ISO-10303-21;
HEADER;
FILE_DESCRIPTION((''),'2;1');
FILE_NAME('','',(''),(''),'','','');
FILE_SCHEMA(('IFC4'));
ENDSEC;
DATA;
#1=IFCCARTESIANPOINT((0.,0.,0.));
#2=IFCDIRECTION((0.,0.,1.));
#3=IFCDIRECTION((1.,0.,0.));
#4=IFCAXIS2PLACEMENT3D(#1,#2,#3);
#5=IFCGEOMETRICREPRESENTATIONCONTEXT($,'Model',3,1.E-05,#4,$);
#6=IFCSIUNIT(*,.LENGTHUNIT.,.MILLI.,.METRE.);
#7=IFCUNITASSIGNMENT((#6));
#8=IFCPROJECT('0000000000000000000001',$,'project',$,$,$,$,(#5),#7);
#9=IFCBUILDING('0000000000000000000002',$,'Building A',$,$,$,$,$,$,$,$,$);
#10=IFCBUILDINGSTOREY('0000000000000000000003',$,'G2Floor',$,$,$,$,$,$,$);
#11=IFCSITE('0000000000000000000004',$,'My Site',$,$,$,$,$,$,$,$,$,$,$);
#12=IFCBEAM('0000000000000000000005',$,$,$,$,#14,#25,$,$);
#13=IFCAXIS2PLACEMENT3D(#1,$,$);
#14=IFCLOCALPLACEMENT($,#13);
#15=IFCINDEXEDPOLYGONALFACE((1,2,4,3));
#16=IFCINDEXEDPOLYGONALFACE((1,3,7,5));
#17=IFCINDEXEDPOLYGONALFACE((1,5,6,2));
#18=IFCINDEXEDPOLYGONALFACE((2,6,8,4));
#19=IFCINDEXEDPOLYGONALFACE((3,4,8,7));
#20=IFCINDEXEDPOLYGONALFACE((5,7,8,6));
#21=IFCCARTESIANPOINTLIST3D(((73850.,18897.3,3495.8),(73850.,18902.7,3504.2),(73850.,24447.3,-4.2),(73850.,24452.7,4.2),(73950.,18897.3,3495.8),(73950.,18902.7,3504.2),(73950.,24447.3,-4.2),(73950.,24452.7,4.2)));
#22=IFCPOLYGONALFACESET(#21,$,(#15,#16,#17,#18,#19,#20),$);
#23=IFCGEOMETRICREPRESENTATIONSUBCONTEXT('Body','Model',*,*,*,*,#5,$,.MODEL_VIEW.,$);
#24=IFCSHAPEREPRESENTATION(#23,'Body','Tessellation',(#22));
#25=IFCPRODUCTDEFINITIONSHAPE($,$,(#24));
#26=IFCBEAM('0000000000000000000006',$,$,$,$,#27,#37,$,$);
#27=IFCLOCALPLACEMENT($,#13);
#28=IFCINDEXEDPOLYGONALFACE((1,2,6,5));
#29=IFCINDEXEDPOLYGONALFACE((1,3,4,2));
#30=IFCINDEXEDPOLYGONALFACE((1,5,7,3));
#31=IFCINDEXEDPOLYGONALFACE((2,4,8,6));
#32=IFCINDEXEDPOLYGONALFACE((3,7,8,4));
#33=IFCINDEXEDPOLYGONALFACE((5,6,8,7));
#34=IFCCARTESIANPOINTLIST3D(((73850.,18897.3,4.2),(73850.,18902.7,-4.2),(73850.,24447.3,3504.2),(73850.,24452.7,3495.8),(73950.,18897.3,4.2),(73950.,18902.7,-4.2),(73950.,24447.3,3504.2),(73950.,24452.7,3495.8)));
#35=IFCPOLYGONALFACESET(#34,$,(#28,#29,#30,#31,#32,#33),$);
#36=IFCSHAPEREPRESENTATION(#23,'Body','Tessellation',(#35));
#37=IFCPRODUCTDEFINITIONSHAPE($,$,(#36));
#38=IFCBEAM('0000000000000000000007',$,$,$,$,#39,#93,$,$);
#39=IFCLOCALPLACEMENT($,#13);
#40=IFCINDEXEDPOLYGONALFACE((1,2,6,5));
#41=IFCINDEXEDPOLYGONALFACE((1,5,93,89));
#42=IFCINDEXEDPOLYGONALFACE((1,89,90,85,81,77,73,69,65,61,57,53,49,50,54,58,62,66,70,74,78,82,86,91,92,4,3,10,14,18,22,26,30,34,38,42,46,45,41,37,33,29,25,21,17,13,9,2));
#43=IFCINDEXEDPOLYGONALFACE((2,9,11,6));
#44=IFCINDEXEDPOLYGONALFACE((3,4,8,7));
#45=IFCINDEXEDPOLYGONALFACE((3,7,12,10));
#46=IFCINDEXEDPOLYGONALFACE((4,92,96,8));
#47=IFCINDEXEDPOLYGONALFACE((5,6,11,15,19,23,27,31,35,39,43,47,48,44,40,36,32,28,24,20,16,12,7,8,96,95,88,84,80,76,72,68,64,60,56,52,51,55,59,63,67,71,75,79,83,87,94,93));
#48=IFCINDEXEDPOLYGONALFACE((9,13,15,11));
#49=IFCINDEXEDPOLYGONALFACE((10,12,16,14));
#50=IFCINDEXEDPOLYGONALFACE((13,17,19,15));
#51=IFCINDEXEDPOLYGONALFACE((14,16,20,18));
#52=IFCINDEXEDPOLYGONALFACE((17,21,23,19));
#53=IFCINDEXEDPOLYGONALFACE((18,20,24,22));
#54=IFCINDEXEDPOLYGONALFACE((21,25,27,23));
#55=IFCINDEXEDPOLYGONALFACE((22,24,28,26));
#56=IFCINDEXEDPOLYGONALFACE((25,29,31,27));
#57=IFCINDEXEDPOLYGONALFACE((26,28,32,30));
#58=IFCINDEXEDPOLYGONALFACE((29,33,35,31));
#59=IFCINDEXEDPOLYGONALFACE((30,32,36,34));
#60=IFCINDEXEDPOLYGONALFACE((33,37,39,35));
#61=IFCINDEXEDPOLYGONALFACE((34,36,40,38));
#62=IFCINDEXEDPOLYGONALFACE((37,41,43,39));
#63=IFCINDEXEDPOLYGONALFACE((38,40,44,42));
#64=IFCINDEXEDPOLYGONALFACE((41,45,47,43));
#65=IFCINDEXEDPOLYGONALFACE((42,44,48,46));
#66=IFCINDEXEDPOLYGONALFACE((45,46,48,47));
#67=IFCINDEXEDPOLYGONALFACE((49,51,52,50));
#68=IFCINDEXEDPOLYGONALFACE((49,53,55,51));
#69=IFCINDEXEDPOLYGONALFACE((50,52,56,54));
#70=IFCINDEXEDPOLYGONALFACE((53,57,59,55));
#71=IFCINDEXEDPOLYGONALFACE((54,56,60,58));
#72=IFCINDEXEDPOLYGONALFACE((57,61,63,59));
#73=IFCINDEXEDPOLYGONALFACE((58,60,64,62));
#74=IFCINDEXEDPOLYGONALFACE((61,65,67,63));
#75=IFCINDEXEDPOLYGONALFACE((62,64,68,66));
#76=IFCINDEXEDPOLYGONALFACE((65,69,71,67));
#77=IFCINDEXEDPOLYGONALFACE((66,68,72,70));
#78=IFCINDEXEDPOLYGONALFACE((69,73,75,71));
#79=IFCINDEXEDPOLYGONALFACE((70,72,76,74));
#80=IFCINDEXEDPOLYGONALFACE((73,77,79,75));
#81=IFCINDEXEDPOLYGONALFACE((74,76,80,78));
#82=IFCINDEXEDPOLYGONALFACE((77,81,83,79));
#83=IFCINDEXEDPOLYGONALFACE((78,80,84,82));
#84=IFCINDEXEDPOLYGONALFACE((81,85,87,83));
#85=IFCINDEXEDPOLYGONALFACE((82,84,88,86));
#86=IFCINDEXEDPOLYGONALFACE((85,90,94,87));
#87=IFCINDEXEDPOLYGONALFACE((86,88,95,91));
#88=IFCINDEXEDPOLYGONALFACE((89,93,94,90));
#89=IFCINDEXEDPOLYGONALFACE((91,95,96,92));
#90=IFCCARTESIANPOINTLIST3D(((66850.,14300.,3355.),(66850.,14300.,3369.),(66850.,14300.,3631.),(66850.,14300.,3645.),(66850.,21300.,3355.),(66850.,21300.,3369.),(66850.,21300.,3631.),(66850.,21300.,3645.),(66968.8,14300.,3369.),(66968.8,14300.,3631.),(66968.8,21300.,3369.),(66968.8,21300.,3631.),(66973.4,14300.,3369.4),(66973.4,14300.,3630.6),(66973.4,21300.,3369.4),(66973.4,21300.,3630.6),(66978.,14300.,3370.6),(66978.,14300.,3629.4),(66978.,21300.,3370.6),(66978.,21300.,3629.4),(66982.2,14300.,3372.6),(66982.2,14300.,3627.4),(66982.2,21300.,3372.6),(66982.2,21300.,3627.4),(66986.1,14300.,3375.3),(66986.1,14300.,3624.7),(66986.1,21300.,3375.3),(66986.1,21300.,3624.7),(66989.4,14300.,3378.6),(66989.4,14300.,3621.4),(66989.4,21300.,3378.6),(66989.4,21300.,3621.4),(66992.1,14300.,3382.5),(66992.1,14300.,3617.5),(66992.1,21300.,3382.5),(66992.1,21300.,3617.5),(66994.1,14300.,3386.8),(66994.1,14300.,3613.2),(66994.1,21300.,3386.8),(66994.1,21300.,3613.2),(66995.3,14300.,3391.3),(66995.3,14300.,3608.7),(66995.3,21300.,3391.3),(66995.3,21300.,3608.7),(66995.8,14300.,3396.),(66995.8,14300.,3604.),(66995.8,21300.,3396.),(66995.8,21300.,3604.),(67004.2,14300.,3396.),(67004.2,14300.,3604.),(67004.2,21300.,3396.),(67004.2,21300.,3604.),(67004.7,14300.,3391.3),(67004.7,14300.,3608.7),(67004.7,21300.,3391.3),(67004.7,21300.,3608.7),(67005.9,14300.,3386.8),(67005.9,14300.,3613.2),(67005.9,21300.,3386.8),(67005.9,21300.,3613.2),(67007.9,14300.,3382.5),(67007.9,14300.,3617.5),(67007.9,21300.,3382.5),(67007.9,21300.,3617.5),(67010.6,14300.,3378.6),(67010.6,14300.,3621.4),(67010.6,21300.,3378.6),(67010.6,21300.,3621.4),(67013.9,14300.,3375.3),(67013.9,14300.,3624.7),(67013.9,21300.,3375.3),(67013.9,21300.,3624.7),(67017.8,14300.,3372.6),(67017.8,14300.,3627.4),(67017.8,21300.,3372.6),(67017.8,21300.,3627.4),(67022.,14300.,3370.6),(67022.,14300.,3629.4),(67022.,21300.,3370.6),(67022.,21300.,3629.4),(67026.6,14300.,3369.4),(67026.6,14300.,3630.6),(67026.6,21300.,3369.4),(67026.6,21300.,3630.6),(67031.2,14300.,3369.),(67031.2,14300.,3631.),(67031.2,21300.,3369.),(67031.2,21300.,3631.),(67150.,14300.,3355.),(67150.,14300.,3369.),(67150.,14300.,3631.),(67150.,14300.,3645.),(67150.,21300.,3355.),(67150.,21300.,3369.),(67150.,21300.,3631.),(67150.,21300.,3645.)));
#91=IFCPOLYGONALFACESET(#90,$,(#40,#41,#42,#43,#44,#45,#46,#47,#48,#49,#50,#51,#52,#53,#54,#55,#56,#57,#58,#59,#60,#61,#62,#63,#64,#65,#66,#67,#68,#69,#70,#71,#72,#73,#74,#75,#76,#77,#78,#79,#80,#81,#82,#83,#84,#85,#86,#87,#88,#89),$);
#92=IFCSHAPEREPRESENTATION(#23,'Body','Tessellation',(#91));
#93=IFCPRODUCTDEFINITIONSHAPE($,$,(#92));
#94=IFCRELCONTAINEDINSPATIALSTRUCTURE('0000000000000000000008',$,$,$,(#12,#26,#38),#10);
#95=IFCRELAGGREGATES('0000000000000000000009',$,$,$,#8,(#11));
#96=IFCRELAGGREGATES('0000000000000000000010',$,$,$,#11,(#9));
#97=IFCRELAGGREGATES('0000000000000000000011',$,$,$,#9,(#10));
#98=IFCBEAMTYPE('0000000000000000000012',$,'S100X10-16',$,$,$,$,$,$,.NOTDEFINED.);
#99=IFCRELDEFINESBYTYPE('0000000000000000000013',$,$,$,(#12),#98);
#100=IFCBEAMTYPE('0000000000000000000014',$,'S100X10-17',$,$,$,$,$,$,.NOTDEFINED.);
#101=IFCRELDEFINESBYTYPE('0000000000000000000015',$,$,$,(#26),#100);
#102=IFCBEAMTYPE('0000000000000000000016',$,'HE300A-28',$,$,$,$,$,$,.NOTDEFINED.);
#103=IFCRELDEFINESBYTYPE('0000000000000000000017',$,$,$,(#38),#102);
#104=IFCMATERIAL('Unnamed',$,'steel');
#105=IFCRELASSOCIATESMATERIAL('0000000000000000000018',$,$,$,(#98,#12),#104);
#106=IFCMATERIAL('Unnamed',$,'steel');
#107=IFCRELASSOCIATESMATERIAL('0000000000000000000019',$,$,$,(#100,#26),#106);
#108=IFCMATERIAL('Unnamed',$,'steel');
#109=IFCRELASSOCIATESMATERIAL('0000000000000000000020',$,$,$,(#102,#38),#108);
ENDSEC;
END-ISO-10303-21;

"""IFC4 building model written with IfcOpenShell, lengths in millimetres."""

from ifc_helpers import new_model, si_unit, frame, origin_with_axes, place, context, subcontext, project, spatial, polyline, outline, extrude, material, material_profile, profile_set, profile_usage, type_object, element, save


model = new_model("IFC4")

# Units and contexts
model_context = context("Model", 3, precision=1e-05, world=origin_with_axes())
body_context = subcontext(model_context, "Body", "Model", "MODEL_VIEW")
ifc_project = project(units=[si_unit("LENGTHUNIT", "METRE", prefix="MILLI")], contexts=[model_context])

# Site, building, storey
site = spatial("IfcSite", under=ifc_project, Name="My Site")
building = spatial("IfcBuilding", under=site, Name="Building A")
storey = spatial("IfcBuildingStorey", under=building, Name="G2Floor")

# Beams
ifc_material_1 = material(Name="Unnamed", Category="steel")
ifc_material_profile_1 = material_profile(ifc_material_1, outline(polyline([(50.0, -5.0), (50.0, 5.0), (50.0, 5.0), (-50.0, 5.0), (-50.0, 5.0), (-50.0, -5.0), (-50.0, -5.0), (50.0, -5.0)])))
ifc_profile_set_1 = profile_set([ifc_material_profile_1], Name="S100X10-16")
ifc_profile_usage_1 = profile_usage(ifc_profile_set_1)
beam_type_1 = type_object("IfcBeamType", Name="S100X10-16", PredefinedType="NOTDEFINED", material=ifc_profile_set_1)
beam_1_placement = place(None, frame((73900.0, 18900.0, 3500.0), z_axis=(0.0, 0.845851, -0.533419), x_axis=(1.0, 0.0, 0.0)))
element("IfcBeam", 1, at=beam_1_placement, inside=storey, type_object=beam_type_1, material=ifc_profile_usage_1, context=body_context, shape_type="SweptSolid", body=[
    extrude(outline(polyline([(50.0, -5.0), (50.0, 5.0), (50.0, 5.0), (-50.0, 5.0), (-50.0, 5.0), (-50.0, -5.0), (-50.0, -5.0), (50.0, -5.0)])), origin_with_axes(), (0.0, 0.0, 1.0), 6561.4),
])
ifc_material_2 = material(Name="Unnamed", Category="steel")
ifc_material_profile_2 = material_profile(ifc_material_2, outline(polyline([(50.0, -5.0), (50.0, 5.0), (50.0, 5.0), (-50.0, 5.0), (-50.0, 5.0), (-50.0, -5.0), (-50.0, -5.0), (50.0, -5.0)])))
ifc_profile_set_2 = profile_set([ifc_material_profile_2], Name="S100X10-17")
ifc_profile_usage_2 = profile_usage(ifc_profile_set_2)
beam_type_2 = type_object("IfcBeamType", Name="S100X10-17", PredefinedType="NOTDEFINED", material=ifc_profile_set_2)
beam_2_placement = place(None, frame((73900.0, 18900.0, 0.0), z_axis=(0.0, 0.845851, 0.533419), x_axis=(1.0, 0.0, 0.0)))
element("IfcBeam", 2, at=beam_2_placement, inside=storey, type_object=beam_type_2, material=ifc_profile_usage_2, context=body_context, shape_type="SweptSolid", body=[
    extrude(outline(polyline([(50.0, -5.0), (50.0, 5.0), (50.0, 5.0), (-50.0, 5.0), (-50.0, 5.0), (-50.0, -5.0), (-50.0, -5.0), (50.0, -5.0)])), origin_with_axes(), (0.0, 0.0, 1.0), 6561.4),
])
ifc_material_3 = material(Name="Unnamed", Category="steel")
ifc_material_profile_3 = material_profile(ifc_material_3, outline(polyline([(150.0, -145.0), (150.0, -131.0), (150.0, -131.0), (31.2, -131.0), (31.2, -131.0), (26.6, -130.6), (26.6, -130.6), (22.0, -129.4), (22.0, -129.4), (17.8, -127.4), (17.8, -127.4), (13.9, -124.7), (13.9, -124.7), (10.6, -121.4), (10.6, -121.4), (7.9, -117.5), (7.9, -117.5), (5.9, -113.2), (5.9, -113.2), (4.7, -108.7), (4.7, -108.7), (4.2, -104.0), (4.2, -104.0), (4.2, 104.0), (4.2, 104.0), (4.7, 108.7), (4.7, 108.7), (5.9, 113.2), (5.9, 113.2), (7.9, 117.5), (7.9, 117.5), (10.6, 121.4), (10.6, 121.4), (13.9, 124.7), (13.9, 124.7), (17.8, 127.4), (17.8, 127.4), (22.0, 129.4), (22.0, 129.4), (26.6, 130.6), (26.6, 130.6), (31.2, 131.0), (31.2, 131.0), (150.0, 131.0), (150.0, 131.0), (150.0, 145.0), (150.0, 145.0), (-150.0, 145.0), (-150.0, 145.0), (-150.0, 131.0), (-150.0, 131.0), (-31.2, 131.0), (-31.2, 131.0), (-26.6, 130.6), (-26.6, 130.6), (-22.0, 129.4), (-22.0, 129.4), (-17.8, 127.4), (-17.8, 127.4), (-13.9, 124.7), (-13.9, 124.7), (-10.6, 121.4), (-10.6, 121.4), (-7.9, 117.5), (-7.9, 117.5), (-5.9, 113.2), (-5.9, 113.2), (-4.7, 108.7), (-4.7, 108.7), (-4.2, 104.0), (-4.2, 104.0), (-4.2, -104.0), (-4.2, -104.0), (-4.7, -108.7), (-4.7, -108.7), (-5.9, -113.2), (-5.9, -113.2), (-7.9, -117.5), (-7.9, -117.5), (-10.6, -121.4), (-10.6, -121.4), (-13.9, -124.7), (-13.9, -124.7), (-17.8, -127.4), (-17.8, -127.4), (-22.0, -129.4), (-22.0, -129.4), (-26.6, -130.6), (-26.6, -130.6), (-31.2, -131.0), (-31.2, -131.0), (-150.0, -131.0), (-150.0, -131.0), (-150.0, -145.0), (-150.0, -145.0), (150.0, -145.0)])))
ifc_profile_set_3 = profile_set([ifc_material_profile_3], Name="HE300A-28")
ifc_profile_usage_3 = profile_usage(ifc_profile_set_3)
beam_type_3 = type_object("IfcBeamType", Name="HE300A-28", PredefinedType="NOTDEFINED", material=ifc_profile_set_3)
beam_3_placement = place(None, frame((67000.0, 14300.0, 3500.0), z_axis=(0.0, 1.0, 0.0), x_axis=(1.0, 0.0, 0.0)))
element("IfcBeam", 3, at=beam_3_placement, inside=storey, type_object=beam_type_3, material=ifc_profile_usage_3, context=body_context, shape_type="SweptSolid", body=[
    extrude(outline(polyline([(150.0, -145.0), (150.0, -131.0), (150.0, -131.0), (31.2, -131.0), (31.2, -131.0), (26.6, -130.6), (26.6, -130.6), (22.0, -129.4), (22.0, -129.4), (17.8, -127.4), (17.8, -127.4), (13.9, -124.7), (13.9, -124.7), (10.6, -121.4), (10.6, -121.4), (7.9, -117.5), (7.9, -117.5), (5.9, -113.2), (5.9, -113.2), (4.7, -108.7), (4.7, -108.7), (4.2, -104.0), (4.2, -104.0), (4.2, 104.0), (4.2, 104.0), (4.7, 108.7), (4.7, 108.7), (5.9, 113.2), (5.9, 113.2), (7.9, 117.5), (7.9, 117.5), (10.6, 121.4), (10.6, 121.4), (13.9, 124.7), (13.9, 124.7), (17.8, 127.4), (17.8, 127.4), (22.0, 129.4), (22.0, 129.4), (26.6, 130.6), (26.6, 130.6), (31.2, 131.0), (31.2, 131.0), (150.0, 131.0), (150.0, 131.0), (150.0, 145.0), (150.0, 145.0), (-150.0, 145.0), (-150.0, 145.0), (-150.0, 131.0), (-150.0, 131.0), (-31.2, 131.0), (-31.2, 131.0), (-26.6, 130.6), (-26.6, 130.6), (-22.0, 129.4), (-22.0, 129.4), (-17.8, 127.4), (-17.8, 127.4), (-13.9, 124.7), (-13.9, 124.7), (-10.6, 121.4), (-10.6, 121.4), (-7.9, 117.5), (-7.9, 117.5), (-5.9, 113.2), (-5.9, 113.2), (-4.7, 108.7), (-4.7, 108.7), (-4.2, 104.0), (-4.2, 104.0), (-4.2, -104.0), (-4.2, -104.0), (-4.7, -108.7), (-4.7, -108.7), (-5.9, -113.2), (-5.9, -113.2), (-7.9, -117.5), (-7.9, -117.5), (-10.6, -121.4), (-10.6, -121.4), (-13.9, -124.7), (-13.9, -124.7), (-17.8, -127.4), (-17.8, -127.4), (-22.0, -129.4), (-22.0, -129.4), (-26.6, -130.6), (-26.6, -130.6), (-31.2, -131.0), (-31.2, -131.0), (-150.0, -131.0), (-150.0, -131.0), (-150.0, -145.0), (-150.0, -145.0), (150.0, -145.0)])), origin_with_axes(), (0.0, 0.0, 1.0), 7000.0),
])

save(model, "model.ifc")
